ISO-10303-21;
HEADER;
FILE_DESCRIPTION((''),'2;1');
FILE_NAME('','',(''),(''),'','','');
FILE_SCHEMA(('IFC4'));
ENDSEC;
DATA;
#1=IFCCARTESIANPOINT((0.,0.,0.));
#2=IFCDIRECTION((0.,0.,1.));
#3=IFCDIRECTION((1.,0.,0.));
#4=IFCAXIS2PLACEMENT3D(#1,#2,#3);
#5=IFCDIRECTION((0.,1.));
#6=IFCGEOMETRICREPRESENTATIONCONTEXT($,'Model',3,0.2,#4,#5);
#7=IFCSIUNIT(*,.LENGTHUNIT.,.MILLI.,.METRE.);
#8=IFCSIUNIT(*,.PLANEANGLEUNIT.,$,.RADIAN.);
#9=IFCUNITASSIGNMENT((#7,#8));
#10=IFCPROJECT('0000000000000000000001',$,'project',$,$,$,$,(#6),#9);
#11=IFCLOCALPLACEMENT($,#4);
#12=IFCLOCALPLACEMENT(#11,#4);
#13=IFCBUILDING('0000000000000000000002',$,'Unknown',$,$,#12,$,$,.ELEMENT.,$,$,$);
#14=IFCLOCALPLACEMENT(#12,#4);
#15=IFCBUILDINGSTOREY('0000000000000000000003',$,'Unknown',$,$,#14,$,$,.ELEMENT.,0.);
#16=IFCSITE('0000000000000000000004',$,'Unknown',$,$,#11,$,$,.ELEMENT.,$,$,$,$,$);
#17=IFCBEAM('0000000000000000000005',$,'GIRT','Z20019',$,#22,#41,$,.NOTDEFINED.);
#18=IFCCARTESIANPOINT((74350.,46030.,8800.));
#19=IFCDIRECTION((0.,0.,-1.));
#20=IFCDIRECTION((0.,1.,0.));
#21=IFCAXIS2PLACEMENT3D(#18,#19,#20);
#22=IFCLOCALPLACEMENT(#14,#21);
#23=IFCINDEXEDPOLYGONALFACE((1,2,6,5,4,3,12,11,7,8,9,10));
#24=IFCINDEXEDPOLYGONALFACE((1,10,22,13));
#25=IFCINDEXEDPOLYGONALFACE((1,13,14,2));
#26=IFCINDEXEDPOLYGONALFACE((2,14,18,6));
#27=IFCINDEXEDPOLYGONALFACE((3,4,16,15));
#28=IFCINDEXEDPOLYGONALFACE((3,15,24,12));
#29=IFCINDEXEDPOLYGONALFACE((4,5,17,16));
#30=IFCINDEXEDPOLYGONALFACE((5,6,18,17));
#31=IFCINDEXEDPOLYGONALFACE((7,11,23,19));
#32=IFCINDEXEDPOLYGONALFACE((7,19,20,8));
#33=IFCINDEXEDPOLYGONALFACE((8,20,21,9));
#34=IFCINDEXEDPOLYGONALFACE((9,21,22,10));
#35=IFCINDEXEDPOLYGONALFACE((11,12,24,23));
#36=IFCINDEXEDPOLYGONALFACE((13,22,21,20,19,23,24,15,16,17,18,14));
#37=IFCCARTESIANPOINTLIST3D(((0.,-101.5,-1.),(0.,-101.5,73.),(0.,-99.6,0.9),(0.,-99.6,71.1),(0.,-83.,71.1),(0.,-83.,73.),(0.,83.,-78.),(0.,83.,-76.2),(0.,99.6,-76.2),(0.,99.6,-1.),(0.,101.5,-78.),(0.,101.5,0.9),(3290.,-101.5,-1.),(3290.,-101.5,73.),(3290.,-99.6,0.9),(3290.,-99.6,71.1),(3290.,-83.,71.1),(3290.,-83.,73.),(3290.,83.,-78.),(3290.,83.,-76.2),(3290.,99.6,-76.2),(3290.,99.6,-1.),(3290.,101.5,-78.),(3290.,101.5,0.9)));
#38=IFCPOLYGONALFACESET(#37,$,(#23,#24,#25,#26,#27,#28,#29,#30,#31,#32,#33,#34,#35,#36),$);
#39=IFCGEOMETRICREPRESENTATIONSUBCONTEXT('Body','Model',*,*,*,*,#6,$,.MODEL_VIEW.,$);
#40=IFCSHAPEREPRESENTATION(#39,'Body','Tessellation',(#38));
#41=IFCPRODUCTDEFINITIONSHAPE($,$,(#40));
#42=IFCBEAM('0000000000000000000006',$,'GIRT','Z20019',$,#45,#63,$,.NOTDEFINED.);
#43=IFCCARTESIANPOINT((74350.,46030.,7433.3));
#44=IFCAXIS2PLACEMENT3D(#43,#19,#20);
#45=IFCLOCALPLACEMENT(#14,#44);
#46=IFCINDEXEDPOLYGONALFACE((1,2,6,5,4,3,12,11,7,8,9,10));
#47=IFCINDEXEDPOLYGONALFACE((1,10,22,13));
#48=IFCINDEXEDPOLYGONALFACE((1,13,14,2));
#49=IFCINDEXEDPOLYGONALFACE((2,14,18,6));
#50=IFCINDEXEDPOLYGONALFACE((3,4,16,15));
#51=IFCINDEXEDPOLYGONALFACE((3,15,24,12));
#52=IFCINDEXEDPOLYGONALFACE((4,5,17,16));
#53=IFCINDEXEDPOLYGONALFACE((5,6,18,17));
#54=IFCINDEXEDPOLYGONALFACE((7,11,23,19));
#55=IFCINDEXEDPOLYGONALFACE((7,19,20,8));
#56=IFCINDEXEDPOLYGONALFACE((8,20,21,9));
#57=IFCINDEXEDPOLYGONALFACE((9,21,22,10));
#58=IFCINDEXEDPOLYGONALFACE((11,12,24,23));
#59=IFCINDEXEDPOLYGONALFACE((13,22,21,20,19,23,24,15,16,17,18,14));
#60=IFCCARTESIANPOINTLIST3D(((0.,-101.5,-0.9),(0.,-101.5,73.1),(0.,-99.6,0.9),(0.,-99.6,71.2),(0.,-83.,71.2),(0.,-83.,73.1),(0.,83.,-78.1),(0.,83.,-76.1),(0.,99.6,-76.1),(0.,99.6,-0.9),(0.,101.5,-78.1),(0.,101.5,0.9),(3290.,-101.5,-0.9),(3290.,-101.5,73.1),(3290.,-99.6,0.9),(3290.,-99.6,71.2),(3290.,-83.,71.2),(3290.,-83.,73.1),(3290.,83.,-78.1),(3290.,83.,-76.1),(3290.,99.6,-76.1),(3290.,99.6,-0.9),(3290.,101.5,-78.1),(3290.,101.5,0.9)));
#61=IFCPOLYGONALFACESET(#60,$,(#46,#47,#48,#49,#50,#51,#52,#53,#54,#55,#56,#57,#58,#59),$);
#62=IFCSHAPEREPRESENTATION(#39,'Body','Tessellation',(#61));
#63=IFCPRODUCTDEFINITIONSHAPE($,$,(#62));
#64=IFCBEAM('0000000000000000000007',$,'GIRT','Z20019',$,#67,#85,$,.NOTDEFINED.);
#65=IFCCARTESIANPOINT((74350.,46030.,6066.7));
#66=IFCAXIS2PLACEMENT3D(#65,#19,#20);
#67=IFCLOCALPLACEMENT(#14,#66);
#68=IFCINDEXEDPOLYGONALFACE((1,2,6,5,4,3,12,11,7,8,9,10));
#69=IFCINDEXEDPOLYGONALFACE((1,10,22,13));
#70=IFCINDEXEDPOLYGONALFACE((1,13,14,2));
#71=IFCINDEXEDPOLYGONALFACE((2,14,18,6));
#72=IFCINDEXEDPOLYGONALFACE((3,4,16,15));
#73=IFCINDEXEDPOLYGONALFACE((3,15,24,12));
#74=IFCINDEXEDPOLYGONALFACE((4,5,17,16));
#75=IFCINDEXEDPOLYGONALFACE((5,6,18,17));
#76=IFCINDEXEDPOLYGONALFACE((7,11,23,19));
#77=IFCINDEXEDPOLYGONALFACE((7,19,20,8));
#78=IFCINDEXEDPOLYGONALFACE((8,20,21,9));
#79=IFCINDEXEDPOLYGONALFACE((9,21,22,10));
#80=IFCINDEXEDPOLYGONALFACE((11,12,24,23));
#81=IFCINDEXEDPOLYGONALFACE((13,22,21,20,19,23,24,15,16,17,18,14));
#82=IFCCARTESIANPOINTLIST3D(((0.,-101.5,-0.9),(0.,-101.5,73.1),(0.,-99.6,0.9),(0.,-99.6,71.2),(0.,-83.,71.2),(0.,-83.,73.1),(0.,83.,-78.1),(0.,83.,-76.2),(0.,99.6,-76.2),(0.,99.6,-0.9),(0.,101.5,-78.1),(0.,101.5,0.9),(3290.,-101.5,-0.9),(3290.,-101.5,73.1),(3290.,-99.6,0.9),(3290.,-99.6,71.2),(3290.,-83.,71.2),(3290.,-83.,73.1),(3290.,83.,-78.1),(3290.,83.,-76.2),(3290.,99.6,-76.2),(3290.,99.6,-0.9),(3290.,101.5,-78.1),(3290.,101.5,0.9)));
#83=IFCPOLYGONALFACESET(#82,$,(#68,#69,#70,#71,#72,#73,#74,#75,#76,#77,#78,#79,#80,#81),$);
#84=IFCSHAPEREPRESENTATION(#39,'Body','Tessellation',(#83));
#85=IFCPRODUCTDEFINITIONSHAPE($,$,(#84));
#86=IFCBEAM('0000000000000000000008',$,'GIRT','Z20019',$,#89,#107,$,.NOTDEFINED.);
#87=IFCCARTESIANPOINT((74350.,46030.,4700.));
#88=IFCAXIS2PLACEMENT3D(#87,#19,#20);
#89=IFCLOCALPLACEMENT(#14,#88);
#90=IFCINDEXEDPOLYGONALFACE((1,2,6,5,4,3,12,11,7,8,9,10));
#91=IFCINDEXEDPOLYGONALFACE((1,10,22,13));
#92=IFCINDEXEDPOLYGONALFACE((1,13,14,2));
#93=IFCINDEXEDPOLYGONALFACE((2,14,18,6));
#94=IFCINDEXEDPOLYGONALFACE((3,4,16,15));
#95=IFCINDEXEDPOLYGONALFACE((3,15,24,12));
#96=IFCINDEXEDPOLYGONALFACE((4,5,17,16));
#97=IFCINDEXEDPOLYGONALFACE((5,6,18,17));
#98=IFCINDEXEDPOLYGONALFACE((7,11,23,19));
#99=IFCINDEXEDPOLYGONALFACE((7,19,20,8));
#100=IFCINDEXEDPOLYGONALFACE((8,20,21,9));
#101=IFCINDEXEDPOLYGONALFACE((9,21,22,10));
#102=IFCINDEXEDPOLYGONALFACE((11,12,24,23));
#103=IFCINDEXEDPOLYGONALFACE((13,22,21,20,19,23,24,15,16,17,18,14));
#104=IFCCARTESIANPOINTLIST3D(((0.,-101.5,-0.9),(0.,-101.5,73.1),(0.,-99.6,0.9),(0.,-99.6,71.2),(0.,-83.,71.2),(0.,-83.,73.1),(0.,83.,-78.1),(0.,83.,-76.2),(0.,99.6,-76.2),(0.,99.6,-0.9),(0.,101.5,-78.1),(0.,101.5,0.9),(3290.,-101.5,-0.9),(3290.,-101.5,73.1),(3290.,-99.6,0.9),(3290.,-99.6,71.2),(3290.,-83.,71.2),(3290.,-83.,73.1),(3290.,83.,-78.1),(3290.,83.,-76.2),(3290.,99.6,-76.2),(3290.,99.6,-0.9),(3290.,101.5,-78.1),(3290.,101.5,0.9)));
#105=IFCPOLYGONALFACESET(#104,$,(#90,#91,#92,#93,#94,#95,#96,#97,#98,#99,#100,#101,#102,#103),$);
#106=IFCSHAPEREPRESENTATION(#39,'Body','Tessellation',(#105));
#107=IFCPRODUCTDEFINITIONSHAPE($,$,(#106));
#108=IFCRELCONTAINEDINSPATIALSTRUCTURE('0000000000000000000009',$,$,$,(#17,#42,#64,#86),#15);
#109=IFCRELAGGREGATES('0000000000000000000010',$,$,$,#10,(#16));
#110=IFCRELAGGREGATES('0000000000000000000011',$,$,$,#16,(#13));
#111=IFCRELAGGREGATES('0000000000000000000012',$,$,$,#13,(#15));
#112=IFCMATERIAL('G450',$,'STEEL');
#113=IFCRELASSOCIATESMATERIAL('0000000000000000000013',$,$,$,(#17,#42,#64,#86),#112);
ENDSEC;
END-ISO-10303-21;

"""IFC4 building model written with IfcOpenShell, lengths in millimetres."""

from ifc_helpers import new_model, si_unit, direction, frame, origin_with_axes, place, context, subcontext, project, spatial, line, indexed_curve, outline, extrude, material, element, save


model = new_model("IFC4")

# Units and contexts
model_context = context("Model", 3, precision=0.2, world=origin_with_axes(), true_north=direction((0.0, 1.0)))
body_context = subcontext(model_context, "Body", "Model", "MODEL_VIEW")
ifc_project = project(units=[si_unit("LENGTHUNIT", "METRE", prefix="MILLI"), si_unit("PLANEANGLEUNIT", "RADIAN")], contexts=[model_context])

# Site, building, storey
site_placement = place(None, origin_with_axes())
site = spatial("IfcSite", under=ifc_project, at=site_placement, Name="Unknown", CompositionType="ELEMENT")
building_placement = place(site_placement, origin_with_axes())
building = spatial("IfcBuilding", under=site, at=building_placement, Name="Unknown", CompositionType="ELEMENT")
storey_placement = place(building_placement, origin_with_axes())
storey = spatial("IfcBuildingStorey", under=building, at=storey_placement, Name="Unknown", CompositionType="ELEMENT", Elevation=0.0)

# Shared definitions
ifc_material_1 = material(Name="G450", Category="STEEL")

# Beams
for number, where, z_axis, x_axis, name in (
    (1, (74350.0, 46030.0, 8800.0), (0.0, 0.0, -1.0), (0.0, 1.0, 0.0), "GIRT"),
    (2, (74350.0, 46030.0, 7433.3), (0.0, 0.0, -1.0), (0.0, 1.0, 0.0), "GIRT"),
    (3, (74350.0, 46030.0, 6066.7), (0.0, 0.0, -1.0), (0.0, 1.0, 0.0), "GIRT"),
    (4, (74350.0, 46030.0, 4700.0), (0.0, 0.0, -1.0), (0.0, 1.0, 0.0), "GIRT"),
):
    element("IfcBeam", number, at=place(storey_placement, frame(where, z_axis=z_axis, x_axis=x_axis)), inside=storey, material=ifc_material_1, Name=name, Description="Z20019", PredefinedType="NOTDEFINED", context=body_context, shape_type="SolidModel", body=[
        extrude(outline(indexed_curve([(73.0, -101.5), (73.0, -83.0), (71.2, -83.0), (71.2, -99.6), (0.9, -99.6), (0.9, 101.5), (-78.0, 101.5), (-78.0, 83.0), (-76.2, 83.0), (-76.2, 99.6), (-0.9, 99.6), (-0.9, -101.5)], segments=[line(1, 2, 3, 4, 5, 6, 7, 8, 9, 10, 11, 12, 1)])), frame((0.0, 0.0, 0.0), z_axis=(-1.0, 0.0, 0.0), x_axis=(0.0, 0.0, 1.0)), (0.0, 0.0, -1.0), 3290.0),
    ])

save(model, "model.ifc")
